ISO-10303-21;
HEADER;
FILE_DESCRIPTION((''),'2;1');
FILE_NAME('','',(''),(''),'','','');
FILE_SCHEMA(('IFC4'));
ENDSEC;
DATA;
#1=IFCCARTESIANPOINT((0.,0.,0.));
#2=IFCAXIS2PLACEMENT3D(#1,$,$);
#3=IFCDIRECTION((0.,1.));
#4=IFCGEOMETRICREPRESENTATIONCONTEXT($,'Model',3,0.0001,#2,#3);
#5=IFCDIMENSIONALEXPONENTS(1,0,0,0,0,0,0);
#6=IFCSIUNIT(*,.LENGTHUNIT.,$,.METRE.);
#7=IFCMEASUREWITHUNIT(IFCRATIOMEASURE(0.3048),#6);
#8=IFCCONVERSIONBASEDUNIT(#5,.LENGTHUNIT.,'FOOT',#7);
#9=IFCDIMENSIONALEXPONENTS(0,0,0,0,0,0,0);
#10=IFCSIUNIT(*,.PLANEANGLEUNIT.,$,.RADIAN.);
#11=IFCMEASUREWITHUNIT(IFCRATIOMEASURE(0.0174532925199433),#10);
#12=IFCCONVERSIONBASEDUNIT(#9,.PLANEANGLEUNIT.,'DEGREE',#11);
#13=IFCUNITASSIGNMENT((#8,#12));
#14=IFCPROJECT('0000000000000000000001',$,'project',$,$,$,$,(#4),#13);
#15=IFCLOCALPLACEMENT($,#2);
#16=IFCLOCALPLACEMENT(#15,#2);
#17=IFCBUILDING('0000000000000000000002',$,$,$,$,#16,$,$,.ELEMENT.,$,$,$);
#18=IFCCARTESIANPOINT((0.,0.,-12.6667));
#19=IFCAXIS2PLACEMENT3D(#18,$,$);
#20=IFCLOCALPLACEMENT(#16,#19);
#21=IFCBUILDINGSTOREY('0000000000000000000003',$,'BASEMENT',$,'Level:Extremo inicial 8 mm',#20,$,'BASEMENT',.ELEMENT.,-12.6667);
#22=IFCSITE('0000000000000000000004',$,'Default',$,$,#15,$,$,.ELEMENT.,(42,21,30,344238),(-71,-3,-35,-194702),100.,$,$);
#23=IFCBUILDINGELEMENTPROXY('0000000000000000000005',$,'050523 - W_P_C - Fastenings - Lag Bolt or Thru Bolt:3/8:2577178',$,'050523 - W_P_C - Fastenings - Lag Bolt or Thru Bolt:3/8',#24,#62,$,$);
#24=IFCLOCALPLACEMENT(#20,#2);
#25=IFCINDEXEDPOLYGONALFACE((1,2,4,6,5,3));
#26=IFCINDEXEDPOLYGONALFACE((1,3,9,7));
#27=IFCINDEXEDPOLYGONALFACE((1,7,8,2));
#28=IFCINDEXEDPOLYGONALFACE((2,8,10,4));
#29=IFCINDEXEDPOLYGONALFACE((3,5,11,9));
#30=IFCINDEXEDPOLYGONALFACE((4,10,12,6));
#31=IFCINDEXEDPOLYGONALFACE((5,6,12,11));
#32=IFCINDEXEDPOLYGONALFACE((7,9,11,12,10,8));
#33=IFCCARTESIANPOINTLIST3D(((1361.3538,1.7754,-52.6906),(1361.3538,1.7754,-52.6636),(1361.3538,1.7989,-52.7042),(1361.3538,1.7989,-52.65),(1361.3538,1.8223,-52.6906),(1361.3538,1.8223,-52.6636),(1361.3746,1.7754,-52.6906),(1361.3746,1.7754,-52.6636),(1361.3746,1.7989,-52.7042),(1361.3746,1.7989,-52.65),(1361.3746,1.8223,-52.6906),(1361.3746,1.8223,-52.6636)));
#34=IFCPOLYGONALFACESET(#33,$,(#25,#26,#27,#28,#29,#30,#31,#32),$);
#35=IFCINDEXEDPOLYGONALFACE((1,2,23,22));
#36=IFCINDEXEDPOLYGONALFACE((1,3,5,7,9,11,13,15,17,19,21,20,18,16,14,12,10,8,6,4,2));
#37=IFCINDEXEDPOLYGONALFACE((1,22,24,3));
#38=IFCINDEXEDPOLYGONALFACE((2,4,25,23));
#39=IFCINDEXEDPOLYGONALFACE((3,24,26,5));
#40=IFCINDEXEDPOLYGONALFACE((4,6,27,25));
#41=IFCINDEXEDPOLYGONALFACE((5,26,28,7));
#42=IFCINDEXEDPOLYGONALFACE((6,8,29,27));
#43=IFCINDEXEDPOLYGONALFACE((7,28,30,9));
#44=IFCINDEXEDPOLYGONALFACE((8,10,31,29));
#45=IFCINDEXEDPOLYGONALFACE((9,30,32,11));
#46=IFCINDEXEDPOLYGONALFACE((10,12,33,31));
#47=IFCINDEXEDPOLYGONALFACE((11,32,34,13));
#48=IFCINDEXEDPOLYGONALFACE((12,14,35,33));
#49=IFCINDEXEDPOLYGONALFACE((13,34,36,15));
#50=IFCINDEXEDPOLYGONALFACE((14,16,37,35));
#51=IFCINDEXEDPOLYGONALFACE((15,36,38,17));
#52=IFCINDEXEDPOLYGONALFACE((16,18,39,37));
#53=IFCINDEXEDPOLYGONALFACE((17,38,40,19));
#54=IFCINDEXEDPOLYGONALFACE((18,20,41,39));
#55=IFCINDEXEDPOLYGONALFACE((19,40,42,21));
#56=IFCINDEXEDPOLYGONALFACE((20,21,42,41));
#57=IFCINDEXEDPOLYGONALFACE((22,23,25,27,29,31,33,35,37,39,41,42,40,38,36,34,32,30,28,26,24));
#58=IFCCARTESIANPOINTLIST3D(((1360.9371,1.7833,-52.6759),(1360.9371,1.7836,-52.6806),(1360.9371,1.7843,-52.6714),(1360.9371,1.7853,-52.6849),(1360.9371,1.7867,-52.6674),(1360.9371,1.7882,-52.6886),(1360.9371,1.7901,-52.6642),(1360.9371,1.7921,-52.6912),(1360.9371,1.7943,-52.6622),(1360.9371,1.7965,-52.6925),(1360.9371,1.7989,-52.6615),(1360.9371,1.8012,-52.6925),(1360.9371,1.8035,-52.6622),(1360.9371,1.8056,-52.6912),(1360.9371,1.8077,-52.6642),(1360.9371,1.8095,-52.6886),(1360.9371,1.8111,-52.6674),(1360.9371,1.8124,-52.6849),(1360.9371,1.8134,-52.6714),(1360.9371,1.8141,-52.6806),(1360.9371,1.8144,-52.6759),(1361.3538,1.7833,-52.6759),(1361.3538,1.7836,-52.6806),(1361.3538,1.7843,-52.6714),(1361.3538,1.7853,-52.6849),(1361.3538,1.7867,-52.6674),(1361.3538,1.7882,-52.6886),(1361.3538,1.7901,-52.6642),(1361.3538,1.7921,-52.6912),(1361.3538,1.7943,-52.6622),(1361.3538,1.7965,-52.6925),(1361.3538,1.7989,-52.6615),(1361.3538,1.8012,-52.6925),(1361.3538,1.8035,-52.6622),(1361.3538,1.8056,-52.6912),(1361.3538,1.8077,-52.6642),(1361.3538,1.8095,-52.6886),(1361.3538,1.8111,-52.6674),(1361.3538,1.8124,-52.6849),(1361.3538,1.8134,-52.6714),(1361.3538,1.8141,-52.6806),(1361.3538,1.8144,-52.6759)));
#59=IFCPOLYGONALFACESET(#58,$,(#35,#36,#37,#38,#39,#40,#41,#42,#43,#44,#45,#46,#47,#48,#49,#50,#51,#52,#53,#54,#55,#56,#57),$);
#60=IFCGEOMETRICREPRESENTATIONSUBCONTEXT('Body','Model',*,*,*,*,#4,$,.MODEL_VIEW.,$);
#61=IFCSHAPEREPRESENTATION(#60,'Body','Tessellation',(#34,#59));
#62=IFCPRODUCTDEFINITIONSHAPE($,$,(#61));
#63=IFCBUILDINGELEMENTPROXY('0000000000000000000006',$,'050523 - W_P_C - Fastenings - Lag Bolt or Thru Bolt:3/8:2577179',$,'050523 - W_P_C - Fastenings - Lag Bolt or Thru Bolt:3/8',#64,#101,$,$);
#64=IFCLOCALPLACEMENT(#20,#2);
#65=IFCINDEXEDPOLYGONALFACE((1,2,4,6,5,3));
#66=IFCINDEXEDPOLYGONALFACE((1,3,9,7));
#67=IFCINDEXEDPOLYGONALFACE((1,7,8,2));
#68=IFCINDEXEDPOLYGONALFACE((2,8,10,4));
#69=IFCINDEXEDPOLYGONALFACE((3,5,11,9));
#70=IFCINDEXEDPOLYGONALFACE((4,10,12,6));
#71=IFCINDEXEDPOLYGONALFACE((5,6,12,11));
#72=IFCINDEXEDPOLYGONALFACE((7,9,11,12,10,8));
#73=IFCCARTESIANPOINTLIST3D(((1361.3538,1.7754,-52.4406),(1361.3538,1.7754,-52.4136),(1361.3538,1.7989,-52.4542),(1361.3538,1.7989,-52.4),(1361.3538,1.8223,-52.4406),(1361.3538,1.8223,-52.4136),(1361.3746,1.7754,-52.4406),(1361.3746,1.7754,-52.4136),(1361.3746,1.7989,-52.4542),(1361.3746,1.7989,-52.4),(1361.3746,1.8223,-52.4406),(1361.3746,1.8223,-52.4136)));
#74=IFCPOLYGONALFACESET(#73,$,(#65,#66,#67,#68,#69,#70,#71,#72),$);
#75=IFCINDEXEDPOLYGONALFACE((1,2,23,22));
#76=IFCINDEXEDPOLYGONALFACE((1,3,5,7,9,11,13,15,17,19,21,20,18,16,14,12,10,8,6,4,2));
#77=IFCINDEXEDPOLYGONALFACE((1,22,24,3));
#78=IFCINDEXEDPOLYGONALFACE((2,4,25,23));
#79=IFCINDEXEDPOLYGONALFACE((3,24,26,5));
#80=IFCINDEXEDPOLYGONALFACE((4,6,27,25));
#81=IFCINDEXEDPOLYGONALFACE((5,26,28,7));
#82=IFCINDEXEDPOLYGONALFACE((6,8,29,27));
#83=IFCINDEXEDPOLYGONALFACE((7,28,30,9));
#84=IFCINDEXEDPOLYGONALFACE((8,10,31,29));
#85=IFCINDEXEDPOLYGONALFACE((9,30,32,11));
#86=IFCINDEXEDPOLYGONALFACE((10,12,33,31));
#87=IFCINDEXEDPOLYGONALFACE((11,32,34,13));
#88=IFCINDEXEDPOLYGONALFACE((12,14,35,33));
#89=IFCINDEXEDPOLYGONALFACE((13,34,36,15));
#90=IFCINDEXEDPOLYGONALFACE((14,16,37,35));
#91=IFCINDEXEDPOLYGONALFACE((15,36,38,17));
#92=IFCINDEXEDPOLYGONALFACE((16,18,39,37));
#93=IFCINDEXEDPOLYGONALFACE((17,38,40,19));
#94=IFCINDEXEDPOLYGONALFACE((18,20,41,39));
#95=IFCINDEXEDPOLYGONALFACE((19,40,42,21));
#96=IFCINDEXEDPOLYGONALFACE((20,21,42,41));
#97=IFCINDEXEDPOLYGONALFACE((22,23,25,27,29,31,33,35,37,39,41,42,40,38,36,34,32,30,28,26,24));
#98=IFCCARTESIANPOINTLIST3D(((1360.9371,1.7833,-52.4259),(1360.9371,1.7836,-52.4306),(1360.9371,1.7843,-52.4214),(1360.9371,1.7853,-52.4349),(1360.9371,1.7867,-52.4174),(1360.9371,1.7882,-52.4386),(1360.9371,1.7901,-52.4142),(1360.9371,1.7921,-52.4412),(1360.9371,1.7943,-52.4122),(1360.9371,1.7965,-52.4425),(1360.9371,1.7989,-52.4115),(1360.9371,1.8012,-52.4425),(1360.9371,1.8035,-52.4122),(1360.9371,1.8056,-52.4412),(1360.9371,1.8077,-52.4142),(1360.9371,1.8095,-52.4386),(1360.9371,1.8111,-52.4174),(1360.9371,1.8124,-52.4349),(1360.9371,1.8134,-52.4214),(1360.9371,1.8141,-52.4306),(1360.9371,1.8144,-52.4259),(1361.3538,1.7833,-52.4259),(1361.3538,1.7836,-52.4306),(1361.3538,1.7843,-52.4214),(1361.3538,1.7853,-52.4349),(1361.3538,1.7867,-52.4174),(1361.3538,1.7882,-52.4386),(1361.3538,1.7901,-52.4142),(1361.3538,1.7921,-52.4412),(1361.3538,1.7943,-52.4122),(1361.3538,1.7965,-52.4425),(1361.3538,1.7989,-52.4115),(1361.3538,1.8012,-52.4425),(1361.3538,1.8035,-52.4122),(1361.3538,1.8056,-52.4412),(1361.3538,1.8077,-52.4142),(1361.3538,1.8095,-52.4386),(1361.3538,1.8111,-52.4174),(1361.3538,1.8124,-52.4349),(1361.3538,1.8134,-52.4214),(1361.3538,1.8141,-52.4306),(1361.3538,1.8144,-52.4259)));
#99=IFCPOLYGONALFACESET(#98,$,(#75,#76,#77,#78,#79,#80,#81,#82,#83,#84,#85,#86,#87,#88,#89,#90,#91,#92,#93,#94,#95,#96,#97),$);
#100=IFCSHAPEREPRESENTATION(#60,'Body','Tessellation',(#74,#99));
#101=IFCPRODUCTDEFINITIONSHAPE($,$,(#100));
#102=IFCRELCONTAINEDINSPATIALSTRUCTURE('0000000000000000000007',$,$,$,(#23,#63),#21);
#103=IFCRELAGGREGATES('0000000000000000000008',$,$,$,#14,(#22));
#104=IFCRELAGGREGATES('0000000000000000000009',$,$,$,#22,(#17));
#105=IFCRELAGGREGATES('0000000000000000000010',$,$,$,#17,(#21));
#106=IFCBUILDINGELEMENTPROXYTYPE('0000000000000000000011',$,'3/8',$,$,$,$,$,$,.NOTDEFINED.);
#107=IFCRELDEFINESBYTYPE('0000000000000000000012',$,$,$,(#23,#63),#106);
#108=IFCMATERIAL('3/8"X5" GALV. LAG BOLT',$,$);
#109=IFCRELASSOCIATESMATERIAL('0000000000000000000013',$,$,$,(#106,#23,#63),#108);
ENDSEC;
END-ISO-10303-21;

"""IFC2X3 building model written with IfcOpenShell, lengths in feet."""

from ifc_helpers import new_model, entity, si_unit, converted_unit, direction, frame, frame_2d, origin, place, context, subcontext, project, spatial, polyline, circle, outline, extrude, source, transform, mapped, material, type_object, type_shapes, element, save


model = new_model("IFC2X3")

# Units and contexts
model_context = context("Model", 3, precision=0.0001, world=origin(), true_north=direction((0.0, 1.0)))
body_context = subcontext(model_context, "Body", "Model", "MODEL_VIEW")
ifc_project = project(units=[converted_unit("LENGTHUNIT", "FOOT", entity("IfcRatioMeasure", 0.3048), si_unit("LENGTHUNIT", "METRE"), dimensions=[1, 0, 0, 0, 0, 0, 0]), converted_unit("PLANEANGLEUNIT", "DEGREE", entity("IfcRatioMeasure", 0.0174532925199433), si_unit("PLANEANGLEUNIT", "RADIAN"), dimensions=[0, 0, 0, 0, 0, 0, 0])], contexts=[model_context])

# Site, building, storey
site_placement = place(None, origin())
site = spatial("IfcSite", under=ifc_project, at=site_placement, Name="Default", CompositionType="ELEMENT", RefLatitude=(42, 21, 30, 344238), RefLongitude=(-71, -3, -35, -194702), RefElevation=100.0)
building_placement = place(site_placement, origin())
building = spatial("IfcBuilding", under=site, at=building_placement, CompositionType="ELEMENT")
storey_placement = place(building_placement, frame((0.0, 0.0, -12.6667)))
storey = spatial("IfcBuildingStorey", under=building, at=storey_placement, Name="BASEMENT", ObjectType="Level:Extremo inicial 8 mm", LongName="BASEMENT", CompositionType="ELEMENT", Elevation=-12.6667)

# Building element proxies
ifc_material = material(Name="3/8\"X5\" GALV. LAG BOLT")
building_element_proxy_type = type_object("IfcBuildingElementProxyType", Name="3/8", PredefinedType="NOTDEFINED", material=ifc_material)
shared_shape = source(origin(), body_context, "Body", "SweptSolid", [
    extrude(outline(polyline([(-0.0135, -0.0234), (0.0135, -0.0234), (0.0271, 0.0), (0.0135, 0.0234), (-0.0135, 0.0234), (-0.0271, 0.0), (-0.0135, -0.0234)])), frame((0.0, 0.0, 0.0), z_axis=(0.0, 0.0, 1.0), x_axis=(0.0, -1.0, 0.0)), (0.0, 0.0, 1.0), 0.0208),
    extrude(circle(Radius=0.0156, at=frame_2d((0.0, 0.0), x_axis=(1.0, 0.0))), frame((0.0, 0.0, -0.4167), z_axis=(0.0, 0.0, 1.0), x_axis=(0.0, 1.0, 0.0)), (0.0, 0.0, 1.0), 0.4167),
])
type_shapes(building_element_proxy_type, [shared_shape])
for number, where, z_axis, x_axis, name in (
    (1, (1361.3538, 1.7989, -52.6771), (1.0, 0.0, 0.0), (0.0, 1.0, 0.0), "050523 - W_P_C - Fastenings - Lag Bolt or Thru Bolt:3/8:2577178"),
    (2, (1361.3538, 1.7989, -52.4271), (1.0, 0.0, 0.0), (0.0, 1.0, 0.0), "050523 - W_P_C - Fastenings - Lag Bolt or Thru Bolt:3/8:2577179"),
):
    element("IfcBuildingElementProxy", number, at=place(storey_placement, frame(where, z_axis=z_axis, x_axis=x_axis)), inside=storey, type_object=building_element_proxy_type, material=ifc_material, Name=name, ObjectType="050523 - W_P_C - Fastenings - Lag Bolt or Thru Bolt:3/8", context=body_context, shape_type="MappedRepresentation", body=[
        mapped(shared_shape, transform((0.0, 0.0, 0.0), scale=1.0)),
    ])

save(model, "model.ifc")
